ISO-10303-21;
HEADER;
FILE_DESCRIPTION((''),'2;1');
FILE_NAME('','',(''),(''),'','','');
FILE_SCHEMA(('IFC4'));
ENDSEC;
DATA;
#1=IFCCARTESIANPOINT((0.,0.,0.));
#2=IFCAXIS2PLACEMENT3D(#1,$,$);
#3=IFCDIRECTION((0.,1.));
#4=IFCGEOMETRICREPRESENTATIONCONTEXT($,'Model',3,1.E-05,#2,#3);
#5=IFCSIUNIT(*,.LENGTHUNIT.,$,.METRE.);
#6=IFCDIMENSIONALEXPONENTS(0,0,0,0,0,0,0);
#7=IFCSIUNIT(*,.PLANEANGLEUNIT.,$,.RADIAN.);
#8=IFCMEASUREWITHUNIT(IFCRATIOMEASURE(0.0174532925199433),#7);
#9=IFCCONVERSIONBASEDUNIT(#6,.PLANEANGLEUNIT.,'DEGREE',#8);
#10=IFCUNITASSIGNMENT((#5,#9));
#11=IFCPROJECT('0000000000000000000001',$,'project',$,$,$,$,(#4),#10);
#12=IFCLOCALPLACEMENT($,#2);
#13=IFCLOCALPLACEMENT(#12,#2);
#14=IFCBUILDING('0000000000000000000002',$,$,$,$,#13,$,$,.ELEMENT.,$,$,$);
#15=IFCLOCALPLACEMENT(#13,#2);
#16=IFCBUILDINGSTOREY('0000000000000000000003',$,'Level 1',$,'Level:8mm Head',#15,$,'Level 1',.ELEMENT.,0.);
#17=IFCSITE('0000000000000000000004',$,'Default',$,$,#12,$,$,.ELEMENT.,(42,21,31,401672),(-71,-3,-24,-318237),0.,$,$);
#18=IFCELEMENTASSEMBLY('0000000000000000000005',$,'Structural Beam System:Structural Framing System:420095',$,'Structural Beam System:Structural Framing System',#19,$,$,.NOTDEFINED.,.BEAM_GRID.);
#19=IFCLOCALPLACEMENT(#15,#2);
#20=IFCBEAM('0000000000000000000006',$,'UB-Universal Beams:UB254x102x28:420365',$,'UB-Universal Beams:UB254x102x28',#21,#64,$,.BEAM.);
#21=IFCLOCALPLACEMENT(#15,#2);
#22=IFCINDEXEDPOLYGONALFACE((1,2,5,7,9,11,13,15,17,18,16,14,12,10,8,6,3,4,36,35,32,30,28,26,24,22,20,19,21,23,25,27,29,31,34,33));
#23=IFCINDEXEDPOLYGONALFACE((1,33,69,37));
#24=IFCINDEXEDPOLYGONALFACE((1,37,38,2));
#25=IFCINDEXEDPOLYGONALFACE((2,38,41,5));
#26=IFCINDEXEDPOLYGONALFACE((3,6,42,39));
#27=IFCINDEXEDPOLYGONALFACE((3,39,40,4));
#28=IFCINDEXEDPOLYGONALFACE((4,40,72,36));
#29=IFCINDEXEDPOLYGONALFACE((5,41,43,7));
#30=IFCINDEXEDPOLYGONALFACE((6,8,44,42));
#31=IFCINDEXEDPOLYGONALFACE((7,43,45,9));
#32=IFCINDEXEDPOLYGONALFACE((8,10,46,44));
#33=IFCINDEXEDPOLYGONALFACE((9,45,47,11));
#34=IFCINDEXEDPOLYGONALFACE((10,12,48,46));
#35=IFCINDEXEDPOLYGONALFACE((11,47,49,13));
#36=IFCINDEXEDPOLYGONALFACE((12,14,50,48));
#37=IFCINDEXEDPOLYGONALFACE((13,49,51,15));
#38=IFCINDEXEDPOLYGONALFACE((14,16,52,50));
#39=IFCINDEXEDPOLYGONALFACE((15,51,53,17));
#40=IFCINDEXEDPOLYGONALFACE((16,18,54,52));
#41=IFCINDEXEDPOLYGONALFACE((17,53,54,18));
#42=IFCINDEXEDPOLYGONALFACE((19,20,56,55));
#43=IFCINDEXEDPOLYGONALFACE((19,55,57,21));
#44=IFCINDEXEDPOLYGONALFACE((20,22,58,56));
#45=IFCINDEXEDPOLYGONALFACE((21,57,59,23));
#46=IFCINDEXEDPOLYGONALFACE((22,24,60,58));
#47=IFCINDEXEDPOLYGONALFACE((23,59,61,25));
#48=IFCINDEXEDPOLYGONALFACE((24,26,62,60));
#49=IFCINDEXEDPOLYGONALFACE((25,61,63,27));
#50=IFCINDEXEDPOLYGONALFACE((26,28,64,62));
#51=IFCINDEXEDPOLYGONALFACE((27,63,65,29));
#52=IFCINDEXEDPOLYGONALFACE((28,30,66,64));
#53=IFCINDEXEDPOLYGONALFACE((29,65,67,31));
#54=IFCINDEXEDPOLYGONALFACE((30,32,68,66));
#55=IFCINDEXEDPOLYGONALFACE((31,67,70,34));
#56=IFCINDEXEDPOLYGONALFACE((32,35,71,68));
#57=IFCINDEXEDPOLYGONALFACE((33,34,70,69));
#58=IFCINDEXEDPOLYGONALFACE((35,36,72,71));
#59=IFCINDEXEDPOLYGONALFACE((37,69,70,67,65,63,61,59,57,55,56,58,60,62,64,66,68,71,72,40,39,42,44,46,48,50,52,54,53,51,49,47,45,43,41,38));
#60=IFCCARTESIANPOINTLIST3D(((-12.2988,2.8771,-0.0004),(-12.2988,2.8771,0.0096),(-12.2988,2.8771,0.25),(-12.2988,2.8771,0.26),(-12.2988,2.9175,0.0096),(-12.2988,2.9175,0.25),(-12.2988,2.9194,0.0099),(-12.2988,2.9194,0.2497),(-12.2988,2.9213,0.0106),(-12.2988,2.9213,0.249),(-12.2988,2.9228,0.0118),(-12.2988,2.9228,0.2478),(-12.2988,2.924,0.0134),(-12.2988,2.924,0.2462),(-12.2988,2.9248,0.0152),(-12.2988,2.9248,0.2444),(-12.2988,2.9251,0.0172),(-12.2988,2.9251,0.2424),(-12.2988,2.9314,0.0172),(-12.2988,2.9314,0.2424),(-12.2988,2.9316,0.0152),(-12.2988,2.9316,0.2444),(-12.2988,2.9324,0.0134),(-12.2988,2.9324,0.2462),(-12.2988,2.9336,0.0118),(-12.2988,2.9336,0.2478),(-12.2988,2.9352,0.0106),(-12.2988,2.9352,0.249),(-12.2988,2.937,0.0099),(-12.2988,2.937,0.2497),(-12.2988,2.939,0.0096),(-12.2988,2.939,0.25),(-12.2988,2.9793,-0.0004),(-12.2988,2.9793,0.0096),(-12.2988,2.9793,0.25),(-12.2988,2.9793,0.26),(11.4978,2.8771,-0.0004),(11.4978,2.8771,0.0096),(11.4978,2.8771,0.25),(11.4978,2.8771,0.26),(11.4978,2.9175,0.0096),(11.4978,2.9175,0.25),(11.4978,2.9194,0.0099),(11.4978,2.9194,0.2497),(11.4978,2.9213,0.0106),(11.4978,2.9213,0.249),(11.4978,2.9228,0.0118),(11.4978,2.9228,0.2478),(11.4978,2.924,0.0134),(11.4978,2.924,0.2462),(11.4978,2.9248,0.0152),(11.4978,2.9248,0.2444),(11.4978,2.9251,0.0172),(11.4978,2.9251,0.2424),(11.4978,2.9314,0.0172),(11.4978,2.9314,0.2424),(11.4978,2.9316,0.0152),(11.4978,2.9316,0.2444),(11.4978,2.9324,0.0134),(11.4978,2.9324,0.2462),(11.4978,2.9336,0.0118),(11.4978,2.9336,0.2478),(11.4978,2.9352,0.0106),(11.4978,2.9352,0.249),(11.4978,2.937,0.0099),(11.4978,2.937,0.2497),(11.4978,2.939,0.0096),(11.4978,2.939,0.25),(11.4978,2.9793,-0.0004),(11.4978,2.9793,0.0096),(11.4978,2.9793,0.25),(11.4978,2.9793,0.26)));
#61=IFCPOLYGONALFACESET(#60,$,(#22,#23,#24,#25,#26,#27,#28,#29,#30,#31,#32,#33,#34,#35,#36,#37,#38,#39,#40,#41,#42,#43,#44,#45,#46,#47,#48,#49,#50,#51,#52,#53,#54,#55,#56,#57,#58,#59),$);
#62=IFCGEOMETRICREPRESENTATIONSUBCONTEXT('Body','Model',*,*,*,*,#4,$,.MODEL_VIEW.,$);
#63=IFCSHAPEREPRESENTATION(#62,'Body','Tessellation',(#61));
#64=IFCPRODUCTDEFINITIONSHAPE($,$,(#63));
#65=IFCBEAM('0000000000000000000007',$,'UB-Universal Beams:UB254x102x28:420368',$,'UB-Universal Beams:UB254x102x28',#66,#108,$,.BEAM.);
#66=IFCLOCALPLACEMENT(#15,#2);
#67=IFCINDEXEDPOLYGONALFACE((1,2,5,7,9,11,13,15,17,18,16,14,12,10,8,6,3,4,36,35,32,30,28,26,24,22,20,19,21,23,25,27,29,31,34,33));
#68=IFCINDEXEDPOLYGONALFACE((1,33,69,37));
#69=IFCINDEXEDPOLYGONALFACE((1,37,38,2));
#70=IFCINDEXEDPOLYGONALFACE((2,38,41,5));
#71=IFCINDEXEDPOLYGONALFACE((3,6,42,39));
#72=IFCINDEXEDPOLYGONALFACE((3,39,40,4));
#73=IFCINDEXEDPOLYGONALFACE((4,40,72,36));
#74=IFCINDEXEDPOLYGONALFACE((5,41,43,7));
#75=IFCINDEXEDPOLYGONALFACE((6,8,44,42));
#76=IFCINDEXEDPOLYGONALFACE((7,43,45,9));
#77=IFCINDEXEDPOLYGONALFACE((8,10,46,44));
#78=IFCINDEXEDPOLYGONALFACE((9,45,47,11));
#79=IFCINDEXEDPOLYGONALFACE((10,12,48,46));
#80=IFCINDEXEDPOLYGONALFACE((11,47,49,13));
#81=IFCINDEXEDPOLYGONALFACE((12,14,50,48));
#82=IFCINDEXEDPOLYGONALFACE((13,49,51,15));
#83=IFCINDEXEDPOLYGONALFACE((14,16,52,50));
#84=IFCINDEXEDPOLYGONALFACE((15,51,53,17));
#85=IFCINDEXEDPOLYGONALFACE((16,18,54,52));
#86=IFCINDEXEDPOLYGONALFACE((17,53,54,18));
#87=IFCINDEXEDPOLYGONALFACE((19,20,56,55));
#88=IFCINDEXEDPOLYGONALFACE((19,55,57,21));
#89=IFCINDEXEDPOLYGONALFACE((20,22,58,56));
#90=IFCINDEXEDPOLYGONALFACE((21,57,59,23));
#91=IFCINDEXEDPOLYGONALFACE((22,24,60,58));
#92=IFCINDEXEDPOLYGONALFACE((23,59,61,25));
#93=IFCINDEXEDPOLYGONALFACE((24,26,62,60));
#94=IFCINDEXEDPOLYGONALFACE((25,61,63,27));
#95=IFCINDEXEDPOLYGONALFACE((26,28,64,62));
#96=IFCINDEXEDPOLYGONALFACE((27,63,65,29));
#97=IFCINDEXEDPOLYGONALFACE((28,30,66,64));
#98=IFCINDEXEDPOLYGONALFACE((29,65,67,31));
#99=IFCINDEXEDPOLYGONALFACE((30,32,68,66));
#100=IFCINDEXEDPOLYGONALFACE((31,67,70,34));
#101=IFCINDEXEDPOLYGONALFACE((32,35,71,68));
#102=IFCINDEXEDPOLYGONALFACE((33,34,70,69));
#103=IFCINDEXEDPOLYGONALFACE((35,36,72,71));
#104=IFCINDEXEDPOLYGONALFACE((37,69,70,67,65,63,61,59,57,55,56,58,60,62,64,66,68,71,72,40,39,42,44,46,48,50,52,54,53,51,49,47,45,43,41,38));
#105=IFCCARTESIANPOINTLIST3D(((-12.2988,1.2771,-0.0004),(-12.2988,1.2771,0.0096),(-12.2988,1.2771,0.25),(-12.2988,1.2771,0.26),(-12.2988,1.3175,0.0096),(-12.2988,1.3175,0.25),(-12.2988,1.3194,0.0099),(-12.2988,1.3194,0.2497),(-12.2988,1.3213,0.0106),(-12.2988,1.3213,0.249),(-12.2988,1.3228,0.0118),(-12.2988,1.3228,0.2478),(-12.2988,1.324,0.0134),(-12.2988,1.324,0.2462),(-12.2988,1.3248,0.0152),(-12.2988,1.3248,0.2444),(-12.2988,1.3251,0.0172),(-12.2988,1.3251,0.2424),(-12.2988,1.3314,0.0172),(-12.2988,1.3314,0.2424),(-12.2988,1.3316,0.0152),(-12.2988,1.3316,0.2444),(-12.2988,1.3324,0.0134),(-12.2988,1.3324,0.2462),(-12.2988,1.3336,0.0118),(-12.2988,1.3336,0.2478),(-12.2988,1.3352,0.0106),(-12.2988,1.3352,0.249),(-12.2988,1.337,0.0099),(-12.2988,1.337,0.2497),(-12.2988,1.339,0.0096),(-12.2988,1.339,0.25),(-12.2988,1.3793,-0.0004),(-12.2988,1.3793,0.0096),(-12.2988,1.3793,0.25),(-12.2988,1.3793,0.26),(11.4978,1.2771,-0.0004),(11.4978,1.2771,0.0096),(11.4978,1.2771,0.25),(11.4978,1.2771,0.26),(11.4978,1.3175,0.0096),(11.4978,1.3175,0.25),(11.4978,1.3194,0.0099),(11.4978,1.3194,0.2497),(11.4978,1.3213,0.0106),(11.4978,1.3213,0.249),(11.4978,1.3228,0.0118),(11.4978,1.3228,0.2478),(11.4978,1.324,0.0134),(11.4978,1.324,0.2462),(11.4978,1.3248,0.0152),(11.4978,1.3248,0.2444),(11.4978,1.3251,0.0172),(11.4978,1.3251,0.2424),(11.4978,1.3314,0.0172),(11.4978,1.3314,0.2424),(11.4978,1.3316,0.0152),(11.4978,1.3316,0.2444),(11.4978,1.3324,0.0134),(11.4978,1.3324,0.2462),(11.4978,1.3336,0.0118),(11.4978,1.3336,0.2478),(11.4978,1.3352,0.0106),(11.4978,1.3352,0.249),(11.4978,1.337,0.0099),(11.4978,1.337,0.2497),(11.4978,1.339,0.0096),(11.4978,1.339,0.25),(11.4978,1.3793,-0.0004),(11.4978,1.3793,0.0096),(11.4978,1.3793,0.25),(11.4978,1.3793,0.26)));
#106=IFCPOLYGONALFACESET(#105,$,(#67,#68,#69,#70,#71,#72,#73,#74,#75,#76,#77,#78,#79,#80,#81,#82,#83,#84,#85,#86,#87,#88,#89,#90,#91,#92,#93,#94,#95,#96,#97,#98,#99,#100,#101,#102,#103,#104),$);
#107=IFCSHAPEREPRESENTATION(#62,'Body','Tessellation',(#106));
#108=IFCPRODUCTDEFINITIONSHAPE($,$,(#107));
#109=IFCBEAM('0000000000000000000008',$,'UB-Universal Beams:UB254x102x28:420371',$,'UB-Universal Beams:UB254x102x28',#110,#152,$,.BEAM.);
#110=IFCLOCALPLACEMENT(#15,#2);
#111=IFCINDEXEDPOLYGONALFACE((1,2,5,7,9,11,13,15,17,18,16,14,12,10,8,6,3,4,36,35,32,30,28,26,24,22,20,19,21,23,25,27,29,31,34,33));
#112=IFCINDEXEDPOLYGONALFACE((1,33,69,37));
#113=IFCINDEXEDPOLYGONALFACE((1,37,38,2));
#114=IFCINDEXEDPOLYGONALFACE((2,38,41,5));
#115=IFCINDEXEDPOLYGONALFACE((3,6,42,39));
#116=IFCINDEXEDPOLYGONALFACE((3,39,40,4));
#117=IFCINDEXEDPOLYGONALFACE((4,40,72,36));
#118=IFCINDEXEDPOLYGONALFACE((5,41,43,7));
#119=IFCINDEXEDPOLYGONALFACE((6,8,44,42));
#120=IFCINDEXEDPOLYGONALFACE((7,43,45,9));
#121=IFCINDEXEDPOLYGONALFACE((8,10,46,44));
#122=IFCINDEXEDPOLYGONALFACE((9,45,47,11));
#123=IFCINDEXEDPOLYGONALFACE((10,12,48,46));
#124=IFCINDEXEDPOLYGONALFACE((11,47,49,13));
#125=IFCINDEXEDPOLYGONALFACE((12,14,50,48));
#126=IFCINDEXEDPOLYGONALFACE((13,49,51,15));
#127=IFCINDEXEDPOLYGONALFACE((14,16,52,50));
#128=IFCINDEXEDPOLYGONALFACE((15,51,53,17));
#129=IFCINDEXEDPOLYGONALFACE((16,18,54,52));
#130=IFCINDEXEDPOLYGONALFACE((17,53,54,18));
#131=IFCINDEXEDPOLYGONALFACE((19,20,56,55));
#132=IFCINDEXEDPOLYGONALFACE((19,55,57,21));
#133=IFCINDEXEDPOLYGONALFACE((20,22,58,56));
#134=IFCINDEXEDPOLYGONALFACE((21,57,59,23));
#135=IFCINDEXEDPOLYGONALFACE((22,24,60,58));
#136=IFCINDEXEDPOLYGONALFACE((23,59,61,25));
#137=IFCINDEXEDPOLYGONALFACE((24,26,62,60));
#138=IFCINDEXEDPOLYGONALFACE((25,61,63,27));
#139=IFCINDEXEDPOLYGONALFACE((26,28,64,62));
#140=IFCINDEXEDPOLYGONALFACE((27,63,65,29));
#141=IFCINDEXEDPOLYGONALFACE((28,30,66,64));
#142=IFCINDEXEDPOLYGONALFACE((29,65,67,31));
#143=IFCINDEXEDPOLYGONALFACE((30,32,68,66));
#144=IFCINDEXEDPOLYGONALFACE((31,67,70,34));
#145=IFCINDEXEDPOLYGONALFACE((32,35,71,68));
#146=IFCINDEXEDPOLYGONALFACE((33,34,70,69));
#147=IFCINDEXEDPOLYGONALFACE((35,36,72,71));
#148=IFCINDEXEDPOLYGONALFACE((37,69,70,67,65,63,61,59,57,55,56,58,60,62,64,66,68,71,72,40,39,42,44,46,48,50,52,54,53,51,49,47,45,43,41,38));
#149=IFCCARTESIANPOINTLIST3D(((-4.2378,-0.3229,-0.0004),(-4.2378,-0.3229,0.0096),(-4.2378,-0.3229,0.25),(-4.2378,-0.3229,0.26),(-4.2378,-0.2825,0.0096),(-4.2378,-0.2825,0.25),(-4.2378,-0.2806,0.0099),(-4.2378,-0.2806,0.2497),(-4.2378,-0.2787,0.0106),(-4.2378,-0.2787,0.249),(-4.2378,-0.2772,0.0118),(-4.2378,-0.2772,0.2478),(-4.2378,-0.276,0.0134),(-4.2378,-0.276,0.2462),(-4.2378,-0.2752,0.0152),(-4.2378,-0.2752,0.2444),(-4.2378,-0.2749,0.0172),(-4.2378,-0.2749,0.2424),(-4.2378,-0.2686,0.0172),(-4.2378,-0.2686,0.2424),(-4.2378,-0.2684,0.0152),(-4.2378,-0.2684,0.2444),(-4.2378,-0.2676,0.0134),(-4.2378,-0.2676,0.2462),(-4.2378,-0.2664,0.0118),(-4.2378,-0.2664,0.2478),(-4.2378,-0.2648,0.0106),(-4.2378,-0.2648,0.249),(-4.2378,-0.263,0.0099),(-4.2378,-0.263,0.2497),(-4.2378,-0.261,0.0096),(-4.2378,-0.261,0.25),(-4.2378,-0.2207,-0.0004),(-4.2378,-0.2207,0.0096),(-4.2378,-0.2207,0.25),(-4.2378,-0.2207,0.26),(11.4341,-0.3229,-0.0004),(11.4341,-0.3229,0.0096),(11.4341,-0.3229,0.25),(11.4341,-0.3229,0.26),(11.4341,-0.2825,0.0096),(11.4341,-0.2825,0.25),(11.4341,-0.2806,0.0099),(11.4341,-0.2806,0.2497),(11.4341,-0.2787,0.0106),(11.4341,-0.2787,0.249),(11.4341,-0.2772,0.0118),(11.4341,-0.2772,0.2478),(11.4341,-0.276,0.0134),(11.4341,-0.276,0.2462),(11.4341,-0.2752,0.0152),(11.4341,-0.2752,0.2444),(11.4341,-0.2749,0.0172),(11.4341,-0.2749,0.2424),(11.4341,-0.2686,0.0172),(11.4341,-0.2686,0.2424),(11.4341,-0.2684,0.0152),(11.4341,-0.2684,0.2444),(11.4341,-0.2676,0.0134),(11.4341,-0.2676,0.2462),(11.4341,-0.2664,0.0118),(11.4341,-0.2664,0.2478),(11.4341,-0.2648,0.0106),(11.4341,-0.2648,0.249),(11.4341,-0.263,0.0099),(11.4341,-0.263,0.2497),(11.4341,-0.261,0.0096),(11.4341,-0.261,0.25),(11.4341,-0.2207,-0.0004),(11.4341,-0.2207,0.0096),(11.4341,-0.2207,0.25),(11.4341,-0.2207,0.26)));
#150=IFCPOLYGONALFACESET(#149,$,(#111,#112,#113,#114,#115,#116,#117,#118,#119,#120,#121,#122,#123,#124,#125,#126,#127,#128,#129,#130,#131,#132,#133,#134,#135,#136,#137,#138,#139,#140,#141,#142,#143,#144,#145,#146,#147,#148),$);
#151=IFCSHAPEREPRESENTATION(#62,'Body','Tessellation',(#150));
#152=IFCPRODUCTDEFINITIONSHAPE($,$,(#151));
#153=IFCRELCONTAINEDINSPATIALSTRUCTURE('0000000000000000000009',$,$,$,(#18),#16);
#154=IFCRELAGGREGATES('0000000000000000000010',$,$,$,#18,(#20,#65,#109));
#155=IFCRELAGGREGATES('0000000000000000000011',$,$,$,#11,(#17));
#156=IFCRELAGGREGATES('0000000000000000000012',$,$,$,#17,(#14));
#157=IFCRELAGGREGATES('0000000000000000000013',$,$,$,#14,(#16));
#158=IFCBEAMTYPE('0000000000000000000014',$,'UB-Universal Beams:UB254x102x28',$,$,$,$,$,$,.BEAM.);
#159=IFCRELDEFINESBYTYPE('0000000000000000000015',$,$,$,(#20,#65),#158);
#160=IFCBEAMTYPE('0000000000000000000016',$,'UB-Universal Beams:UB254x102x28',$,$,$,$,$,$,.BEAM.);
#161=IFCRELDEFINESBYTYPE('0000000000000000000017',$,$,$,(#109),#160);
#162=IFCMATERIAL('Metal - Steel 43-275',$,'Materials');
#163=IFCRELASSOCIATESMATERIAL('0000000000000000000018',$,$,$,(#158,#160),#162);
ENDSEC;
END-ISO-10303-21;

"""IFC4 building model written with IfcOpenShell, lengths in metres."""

from ifc_helpers import new_model, entity, si_unit, converted_unit, direction, frame, frame_2d, origin, place, context, subcontext, project, spatial, i_section, extrude, source, transform, mapped, material, material_profile, profile_set, type_object, type_shapes, element, aggregate, save


model = new_model("IFC4")

# Units and contexts
model_context = context("Model", 3, precision=1e-05, world=origin(), true_north=direction((0.0, 1.0)))
body_context = subcontext(model_context, "Body", "Model", "MODEL_VIEW")
ifc_project = project(units=[si_unit("LENGTHUNIT", "METRE"), converted_unit("PLANEANGLEUNIT", "DEGREE", entity("IfcRatioMeasure", 0.0174532925199433), si_unit("PLANEANGLEUNIT", "RADIAN"), dimensions=[0, 0, 0, 0, 0, 0, 0])], contexts=[model_context])

# Site, building, storey
site_placement = place(None, origin())
site = spatial("IfcSite", under=ifc_project, at=site_placement, Name="Default", CompositionType="ELEMENT", RefLatitude=(42, 21, 31, 401672), RefLongitude=(-71, -3, -24, -318237), RefElevation=0.0)
building_placement = place(site_placement, origin())
building = spatial("IfcBuilding", under=site, at=building_placement, CompositionType="ELEMENT")
storey_placement = place(building_placement, origin())
storey = spatial("IfcBuildingStorey", under=building, at=storey_placement, Name="Level 1", ObjectType="Level:8mm Head", LongName="Level 1", CompositionType="ELEMENT", Elevation=0.0)

# Shared definitions
ifc_material_1 = material(Name="Metal - Steel 43-275", Category="Materials")

# Element assembly, beams
assembly_placement = place(storey_placement, origin())
assembly = element("IfcElementAssembly", 1, at=assembly_placement, inside=storey, Name="Structural Beam System:Structural Framing System:420095", ObjectType="Structural Beam System:Structural Framing System", AssemblyPlace="NOTDEFINED", PredefinedType="BEAM_GRID")
ifc_material_profile_1 = material_profile(ifc_material_1, i_section(OverallWidth=0.1022, OverallDepth=0.2604, WebThickness=0.0063, FlangeThickness=0.01, FilletRadius=0.0076, at=frame_2d((0.0, 0.0), x_axis=(0.0, 1.0))), Name="UB254x102x28")
ifc_profile_set_1 = profile_set([ifc_material_profile_1], Name="UB254x102x28")
beam_type_1 = type_object("IfcBeamType", Name="UB-Universal Beams:UB254x102x28", PredefinedType="BEAM", material=ifc_profile_set_1)
shared_shape_1 = source(origin(), body_context, "Body", "SweptSolid", [
    extrude(i_section(OverallWidth=0.1022, OverallDepth=0.2604, WebThickness=0.0063, FlangeThickness=0.01, FilletRadius=0.0076, at=frame_2d((0.0, 0.0), x_axis=(0.0, 1.0))), frame((-11.8983, 0.0, 0.0), z_axis=(1.0, 0.0, 0.0), x_axis=(0.0, 0.0, -1.0)), (0.0, 0.0, 1.0), 23.7966),
])
type_shapes(beam_type_1, [shared_shape_1])
beam_1_placement = place(assembly_placement, frame((-0.4005, 2.9282, 0.1298)))
beam_1 = element("IfcBeam", 2, at=beam_1_placement, type_object=beam_type_1, Name="UB-Universal Beams:UB254x102x28:420365", ObjectType="UB-Universal Beams:UB254x102x28", PredefinedType="BEAM", context=body_context, shape_type="MappedRepresentation", body=[
    mapped(shared_shape_1, transform((0.0, 0.0, 0.0), scale=1.0)),
])
beam_2_placement = place(assembly_placement, frame((-0.4005, 1.3282, 0.1298)))
beam_2 = element("IfcBeam", 3, at=beam_2_placement, type_object=beam_type_1, Name="UB-Universal Beams:UB254x102x28:420368", ObjectType="UB-Universal Beams:UB254x102x28", PredefinedType="BEAM", context=body_context, shape_type="MappedRepresentation", body=[
    mapped(shared_shape_1, transform((0.0, 0.0, 0.0), scale=1.0)),
])
beam_type_2 = type_object("IfcBeamType", Name="UB-Universal Beams:UB254x102x28", PredefinedType="BEAM", material=ifc_profile_set_1)
shared_shape_2 = source(origin(), body_context, "Body", "SweptSolid", [
    extrude(i_section(OverallWidth=0.1022, OverallDepth=0.2604, WebThickness=0.0063, FlangeThickness=0.01, FilletRadius=0.0076, at=frame_2d((0.0, 0.0), x_axis=(0.0, 1.0))), frame((-7.8818, 0.0, 0.0), z_axis=(1.0, 0.0, 0.0), x_axis=(0.0, 0.0, -1.0)), (0.0, 0.0, 1.0), 15.6719),
])
type_shapes(beam_type_2, [shared_shape_2])
beam_3_placement = place(assembly_placement, frame((3.644, -0.2718, 0.1298)))
beam_3 = element("IfcBeam", 4, at=beam_3_placement, type_object=beam_type_2, Name="UB-Universal Beams:UB254x102x28:420371", ObjectType="UB-Universal Beams:UB254x102x28", PredefinedType="BEAM", context=body_context, shape_type="MappedRepresentation", body=[
    mapped(shared_shape_2, transform((0.0, 0.0, 0.0), scale=1.0)),
])
aggregate(assembly, [beam_1, beam_2, beam_3])

save(model, "model.ifc")
